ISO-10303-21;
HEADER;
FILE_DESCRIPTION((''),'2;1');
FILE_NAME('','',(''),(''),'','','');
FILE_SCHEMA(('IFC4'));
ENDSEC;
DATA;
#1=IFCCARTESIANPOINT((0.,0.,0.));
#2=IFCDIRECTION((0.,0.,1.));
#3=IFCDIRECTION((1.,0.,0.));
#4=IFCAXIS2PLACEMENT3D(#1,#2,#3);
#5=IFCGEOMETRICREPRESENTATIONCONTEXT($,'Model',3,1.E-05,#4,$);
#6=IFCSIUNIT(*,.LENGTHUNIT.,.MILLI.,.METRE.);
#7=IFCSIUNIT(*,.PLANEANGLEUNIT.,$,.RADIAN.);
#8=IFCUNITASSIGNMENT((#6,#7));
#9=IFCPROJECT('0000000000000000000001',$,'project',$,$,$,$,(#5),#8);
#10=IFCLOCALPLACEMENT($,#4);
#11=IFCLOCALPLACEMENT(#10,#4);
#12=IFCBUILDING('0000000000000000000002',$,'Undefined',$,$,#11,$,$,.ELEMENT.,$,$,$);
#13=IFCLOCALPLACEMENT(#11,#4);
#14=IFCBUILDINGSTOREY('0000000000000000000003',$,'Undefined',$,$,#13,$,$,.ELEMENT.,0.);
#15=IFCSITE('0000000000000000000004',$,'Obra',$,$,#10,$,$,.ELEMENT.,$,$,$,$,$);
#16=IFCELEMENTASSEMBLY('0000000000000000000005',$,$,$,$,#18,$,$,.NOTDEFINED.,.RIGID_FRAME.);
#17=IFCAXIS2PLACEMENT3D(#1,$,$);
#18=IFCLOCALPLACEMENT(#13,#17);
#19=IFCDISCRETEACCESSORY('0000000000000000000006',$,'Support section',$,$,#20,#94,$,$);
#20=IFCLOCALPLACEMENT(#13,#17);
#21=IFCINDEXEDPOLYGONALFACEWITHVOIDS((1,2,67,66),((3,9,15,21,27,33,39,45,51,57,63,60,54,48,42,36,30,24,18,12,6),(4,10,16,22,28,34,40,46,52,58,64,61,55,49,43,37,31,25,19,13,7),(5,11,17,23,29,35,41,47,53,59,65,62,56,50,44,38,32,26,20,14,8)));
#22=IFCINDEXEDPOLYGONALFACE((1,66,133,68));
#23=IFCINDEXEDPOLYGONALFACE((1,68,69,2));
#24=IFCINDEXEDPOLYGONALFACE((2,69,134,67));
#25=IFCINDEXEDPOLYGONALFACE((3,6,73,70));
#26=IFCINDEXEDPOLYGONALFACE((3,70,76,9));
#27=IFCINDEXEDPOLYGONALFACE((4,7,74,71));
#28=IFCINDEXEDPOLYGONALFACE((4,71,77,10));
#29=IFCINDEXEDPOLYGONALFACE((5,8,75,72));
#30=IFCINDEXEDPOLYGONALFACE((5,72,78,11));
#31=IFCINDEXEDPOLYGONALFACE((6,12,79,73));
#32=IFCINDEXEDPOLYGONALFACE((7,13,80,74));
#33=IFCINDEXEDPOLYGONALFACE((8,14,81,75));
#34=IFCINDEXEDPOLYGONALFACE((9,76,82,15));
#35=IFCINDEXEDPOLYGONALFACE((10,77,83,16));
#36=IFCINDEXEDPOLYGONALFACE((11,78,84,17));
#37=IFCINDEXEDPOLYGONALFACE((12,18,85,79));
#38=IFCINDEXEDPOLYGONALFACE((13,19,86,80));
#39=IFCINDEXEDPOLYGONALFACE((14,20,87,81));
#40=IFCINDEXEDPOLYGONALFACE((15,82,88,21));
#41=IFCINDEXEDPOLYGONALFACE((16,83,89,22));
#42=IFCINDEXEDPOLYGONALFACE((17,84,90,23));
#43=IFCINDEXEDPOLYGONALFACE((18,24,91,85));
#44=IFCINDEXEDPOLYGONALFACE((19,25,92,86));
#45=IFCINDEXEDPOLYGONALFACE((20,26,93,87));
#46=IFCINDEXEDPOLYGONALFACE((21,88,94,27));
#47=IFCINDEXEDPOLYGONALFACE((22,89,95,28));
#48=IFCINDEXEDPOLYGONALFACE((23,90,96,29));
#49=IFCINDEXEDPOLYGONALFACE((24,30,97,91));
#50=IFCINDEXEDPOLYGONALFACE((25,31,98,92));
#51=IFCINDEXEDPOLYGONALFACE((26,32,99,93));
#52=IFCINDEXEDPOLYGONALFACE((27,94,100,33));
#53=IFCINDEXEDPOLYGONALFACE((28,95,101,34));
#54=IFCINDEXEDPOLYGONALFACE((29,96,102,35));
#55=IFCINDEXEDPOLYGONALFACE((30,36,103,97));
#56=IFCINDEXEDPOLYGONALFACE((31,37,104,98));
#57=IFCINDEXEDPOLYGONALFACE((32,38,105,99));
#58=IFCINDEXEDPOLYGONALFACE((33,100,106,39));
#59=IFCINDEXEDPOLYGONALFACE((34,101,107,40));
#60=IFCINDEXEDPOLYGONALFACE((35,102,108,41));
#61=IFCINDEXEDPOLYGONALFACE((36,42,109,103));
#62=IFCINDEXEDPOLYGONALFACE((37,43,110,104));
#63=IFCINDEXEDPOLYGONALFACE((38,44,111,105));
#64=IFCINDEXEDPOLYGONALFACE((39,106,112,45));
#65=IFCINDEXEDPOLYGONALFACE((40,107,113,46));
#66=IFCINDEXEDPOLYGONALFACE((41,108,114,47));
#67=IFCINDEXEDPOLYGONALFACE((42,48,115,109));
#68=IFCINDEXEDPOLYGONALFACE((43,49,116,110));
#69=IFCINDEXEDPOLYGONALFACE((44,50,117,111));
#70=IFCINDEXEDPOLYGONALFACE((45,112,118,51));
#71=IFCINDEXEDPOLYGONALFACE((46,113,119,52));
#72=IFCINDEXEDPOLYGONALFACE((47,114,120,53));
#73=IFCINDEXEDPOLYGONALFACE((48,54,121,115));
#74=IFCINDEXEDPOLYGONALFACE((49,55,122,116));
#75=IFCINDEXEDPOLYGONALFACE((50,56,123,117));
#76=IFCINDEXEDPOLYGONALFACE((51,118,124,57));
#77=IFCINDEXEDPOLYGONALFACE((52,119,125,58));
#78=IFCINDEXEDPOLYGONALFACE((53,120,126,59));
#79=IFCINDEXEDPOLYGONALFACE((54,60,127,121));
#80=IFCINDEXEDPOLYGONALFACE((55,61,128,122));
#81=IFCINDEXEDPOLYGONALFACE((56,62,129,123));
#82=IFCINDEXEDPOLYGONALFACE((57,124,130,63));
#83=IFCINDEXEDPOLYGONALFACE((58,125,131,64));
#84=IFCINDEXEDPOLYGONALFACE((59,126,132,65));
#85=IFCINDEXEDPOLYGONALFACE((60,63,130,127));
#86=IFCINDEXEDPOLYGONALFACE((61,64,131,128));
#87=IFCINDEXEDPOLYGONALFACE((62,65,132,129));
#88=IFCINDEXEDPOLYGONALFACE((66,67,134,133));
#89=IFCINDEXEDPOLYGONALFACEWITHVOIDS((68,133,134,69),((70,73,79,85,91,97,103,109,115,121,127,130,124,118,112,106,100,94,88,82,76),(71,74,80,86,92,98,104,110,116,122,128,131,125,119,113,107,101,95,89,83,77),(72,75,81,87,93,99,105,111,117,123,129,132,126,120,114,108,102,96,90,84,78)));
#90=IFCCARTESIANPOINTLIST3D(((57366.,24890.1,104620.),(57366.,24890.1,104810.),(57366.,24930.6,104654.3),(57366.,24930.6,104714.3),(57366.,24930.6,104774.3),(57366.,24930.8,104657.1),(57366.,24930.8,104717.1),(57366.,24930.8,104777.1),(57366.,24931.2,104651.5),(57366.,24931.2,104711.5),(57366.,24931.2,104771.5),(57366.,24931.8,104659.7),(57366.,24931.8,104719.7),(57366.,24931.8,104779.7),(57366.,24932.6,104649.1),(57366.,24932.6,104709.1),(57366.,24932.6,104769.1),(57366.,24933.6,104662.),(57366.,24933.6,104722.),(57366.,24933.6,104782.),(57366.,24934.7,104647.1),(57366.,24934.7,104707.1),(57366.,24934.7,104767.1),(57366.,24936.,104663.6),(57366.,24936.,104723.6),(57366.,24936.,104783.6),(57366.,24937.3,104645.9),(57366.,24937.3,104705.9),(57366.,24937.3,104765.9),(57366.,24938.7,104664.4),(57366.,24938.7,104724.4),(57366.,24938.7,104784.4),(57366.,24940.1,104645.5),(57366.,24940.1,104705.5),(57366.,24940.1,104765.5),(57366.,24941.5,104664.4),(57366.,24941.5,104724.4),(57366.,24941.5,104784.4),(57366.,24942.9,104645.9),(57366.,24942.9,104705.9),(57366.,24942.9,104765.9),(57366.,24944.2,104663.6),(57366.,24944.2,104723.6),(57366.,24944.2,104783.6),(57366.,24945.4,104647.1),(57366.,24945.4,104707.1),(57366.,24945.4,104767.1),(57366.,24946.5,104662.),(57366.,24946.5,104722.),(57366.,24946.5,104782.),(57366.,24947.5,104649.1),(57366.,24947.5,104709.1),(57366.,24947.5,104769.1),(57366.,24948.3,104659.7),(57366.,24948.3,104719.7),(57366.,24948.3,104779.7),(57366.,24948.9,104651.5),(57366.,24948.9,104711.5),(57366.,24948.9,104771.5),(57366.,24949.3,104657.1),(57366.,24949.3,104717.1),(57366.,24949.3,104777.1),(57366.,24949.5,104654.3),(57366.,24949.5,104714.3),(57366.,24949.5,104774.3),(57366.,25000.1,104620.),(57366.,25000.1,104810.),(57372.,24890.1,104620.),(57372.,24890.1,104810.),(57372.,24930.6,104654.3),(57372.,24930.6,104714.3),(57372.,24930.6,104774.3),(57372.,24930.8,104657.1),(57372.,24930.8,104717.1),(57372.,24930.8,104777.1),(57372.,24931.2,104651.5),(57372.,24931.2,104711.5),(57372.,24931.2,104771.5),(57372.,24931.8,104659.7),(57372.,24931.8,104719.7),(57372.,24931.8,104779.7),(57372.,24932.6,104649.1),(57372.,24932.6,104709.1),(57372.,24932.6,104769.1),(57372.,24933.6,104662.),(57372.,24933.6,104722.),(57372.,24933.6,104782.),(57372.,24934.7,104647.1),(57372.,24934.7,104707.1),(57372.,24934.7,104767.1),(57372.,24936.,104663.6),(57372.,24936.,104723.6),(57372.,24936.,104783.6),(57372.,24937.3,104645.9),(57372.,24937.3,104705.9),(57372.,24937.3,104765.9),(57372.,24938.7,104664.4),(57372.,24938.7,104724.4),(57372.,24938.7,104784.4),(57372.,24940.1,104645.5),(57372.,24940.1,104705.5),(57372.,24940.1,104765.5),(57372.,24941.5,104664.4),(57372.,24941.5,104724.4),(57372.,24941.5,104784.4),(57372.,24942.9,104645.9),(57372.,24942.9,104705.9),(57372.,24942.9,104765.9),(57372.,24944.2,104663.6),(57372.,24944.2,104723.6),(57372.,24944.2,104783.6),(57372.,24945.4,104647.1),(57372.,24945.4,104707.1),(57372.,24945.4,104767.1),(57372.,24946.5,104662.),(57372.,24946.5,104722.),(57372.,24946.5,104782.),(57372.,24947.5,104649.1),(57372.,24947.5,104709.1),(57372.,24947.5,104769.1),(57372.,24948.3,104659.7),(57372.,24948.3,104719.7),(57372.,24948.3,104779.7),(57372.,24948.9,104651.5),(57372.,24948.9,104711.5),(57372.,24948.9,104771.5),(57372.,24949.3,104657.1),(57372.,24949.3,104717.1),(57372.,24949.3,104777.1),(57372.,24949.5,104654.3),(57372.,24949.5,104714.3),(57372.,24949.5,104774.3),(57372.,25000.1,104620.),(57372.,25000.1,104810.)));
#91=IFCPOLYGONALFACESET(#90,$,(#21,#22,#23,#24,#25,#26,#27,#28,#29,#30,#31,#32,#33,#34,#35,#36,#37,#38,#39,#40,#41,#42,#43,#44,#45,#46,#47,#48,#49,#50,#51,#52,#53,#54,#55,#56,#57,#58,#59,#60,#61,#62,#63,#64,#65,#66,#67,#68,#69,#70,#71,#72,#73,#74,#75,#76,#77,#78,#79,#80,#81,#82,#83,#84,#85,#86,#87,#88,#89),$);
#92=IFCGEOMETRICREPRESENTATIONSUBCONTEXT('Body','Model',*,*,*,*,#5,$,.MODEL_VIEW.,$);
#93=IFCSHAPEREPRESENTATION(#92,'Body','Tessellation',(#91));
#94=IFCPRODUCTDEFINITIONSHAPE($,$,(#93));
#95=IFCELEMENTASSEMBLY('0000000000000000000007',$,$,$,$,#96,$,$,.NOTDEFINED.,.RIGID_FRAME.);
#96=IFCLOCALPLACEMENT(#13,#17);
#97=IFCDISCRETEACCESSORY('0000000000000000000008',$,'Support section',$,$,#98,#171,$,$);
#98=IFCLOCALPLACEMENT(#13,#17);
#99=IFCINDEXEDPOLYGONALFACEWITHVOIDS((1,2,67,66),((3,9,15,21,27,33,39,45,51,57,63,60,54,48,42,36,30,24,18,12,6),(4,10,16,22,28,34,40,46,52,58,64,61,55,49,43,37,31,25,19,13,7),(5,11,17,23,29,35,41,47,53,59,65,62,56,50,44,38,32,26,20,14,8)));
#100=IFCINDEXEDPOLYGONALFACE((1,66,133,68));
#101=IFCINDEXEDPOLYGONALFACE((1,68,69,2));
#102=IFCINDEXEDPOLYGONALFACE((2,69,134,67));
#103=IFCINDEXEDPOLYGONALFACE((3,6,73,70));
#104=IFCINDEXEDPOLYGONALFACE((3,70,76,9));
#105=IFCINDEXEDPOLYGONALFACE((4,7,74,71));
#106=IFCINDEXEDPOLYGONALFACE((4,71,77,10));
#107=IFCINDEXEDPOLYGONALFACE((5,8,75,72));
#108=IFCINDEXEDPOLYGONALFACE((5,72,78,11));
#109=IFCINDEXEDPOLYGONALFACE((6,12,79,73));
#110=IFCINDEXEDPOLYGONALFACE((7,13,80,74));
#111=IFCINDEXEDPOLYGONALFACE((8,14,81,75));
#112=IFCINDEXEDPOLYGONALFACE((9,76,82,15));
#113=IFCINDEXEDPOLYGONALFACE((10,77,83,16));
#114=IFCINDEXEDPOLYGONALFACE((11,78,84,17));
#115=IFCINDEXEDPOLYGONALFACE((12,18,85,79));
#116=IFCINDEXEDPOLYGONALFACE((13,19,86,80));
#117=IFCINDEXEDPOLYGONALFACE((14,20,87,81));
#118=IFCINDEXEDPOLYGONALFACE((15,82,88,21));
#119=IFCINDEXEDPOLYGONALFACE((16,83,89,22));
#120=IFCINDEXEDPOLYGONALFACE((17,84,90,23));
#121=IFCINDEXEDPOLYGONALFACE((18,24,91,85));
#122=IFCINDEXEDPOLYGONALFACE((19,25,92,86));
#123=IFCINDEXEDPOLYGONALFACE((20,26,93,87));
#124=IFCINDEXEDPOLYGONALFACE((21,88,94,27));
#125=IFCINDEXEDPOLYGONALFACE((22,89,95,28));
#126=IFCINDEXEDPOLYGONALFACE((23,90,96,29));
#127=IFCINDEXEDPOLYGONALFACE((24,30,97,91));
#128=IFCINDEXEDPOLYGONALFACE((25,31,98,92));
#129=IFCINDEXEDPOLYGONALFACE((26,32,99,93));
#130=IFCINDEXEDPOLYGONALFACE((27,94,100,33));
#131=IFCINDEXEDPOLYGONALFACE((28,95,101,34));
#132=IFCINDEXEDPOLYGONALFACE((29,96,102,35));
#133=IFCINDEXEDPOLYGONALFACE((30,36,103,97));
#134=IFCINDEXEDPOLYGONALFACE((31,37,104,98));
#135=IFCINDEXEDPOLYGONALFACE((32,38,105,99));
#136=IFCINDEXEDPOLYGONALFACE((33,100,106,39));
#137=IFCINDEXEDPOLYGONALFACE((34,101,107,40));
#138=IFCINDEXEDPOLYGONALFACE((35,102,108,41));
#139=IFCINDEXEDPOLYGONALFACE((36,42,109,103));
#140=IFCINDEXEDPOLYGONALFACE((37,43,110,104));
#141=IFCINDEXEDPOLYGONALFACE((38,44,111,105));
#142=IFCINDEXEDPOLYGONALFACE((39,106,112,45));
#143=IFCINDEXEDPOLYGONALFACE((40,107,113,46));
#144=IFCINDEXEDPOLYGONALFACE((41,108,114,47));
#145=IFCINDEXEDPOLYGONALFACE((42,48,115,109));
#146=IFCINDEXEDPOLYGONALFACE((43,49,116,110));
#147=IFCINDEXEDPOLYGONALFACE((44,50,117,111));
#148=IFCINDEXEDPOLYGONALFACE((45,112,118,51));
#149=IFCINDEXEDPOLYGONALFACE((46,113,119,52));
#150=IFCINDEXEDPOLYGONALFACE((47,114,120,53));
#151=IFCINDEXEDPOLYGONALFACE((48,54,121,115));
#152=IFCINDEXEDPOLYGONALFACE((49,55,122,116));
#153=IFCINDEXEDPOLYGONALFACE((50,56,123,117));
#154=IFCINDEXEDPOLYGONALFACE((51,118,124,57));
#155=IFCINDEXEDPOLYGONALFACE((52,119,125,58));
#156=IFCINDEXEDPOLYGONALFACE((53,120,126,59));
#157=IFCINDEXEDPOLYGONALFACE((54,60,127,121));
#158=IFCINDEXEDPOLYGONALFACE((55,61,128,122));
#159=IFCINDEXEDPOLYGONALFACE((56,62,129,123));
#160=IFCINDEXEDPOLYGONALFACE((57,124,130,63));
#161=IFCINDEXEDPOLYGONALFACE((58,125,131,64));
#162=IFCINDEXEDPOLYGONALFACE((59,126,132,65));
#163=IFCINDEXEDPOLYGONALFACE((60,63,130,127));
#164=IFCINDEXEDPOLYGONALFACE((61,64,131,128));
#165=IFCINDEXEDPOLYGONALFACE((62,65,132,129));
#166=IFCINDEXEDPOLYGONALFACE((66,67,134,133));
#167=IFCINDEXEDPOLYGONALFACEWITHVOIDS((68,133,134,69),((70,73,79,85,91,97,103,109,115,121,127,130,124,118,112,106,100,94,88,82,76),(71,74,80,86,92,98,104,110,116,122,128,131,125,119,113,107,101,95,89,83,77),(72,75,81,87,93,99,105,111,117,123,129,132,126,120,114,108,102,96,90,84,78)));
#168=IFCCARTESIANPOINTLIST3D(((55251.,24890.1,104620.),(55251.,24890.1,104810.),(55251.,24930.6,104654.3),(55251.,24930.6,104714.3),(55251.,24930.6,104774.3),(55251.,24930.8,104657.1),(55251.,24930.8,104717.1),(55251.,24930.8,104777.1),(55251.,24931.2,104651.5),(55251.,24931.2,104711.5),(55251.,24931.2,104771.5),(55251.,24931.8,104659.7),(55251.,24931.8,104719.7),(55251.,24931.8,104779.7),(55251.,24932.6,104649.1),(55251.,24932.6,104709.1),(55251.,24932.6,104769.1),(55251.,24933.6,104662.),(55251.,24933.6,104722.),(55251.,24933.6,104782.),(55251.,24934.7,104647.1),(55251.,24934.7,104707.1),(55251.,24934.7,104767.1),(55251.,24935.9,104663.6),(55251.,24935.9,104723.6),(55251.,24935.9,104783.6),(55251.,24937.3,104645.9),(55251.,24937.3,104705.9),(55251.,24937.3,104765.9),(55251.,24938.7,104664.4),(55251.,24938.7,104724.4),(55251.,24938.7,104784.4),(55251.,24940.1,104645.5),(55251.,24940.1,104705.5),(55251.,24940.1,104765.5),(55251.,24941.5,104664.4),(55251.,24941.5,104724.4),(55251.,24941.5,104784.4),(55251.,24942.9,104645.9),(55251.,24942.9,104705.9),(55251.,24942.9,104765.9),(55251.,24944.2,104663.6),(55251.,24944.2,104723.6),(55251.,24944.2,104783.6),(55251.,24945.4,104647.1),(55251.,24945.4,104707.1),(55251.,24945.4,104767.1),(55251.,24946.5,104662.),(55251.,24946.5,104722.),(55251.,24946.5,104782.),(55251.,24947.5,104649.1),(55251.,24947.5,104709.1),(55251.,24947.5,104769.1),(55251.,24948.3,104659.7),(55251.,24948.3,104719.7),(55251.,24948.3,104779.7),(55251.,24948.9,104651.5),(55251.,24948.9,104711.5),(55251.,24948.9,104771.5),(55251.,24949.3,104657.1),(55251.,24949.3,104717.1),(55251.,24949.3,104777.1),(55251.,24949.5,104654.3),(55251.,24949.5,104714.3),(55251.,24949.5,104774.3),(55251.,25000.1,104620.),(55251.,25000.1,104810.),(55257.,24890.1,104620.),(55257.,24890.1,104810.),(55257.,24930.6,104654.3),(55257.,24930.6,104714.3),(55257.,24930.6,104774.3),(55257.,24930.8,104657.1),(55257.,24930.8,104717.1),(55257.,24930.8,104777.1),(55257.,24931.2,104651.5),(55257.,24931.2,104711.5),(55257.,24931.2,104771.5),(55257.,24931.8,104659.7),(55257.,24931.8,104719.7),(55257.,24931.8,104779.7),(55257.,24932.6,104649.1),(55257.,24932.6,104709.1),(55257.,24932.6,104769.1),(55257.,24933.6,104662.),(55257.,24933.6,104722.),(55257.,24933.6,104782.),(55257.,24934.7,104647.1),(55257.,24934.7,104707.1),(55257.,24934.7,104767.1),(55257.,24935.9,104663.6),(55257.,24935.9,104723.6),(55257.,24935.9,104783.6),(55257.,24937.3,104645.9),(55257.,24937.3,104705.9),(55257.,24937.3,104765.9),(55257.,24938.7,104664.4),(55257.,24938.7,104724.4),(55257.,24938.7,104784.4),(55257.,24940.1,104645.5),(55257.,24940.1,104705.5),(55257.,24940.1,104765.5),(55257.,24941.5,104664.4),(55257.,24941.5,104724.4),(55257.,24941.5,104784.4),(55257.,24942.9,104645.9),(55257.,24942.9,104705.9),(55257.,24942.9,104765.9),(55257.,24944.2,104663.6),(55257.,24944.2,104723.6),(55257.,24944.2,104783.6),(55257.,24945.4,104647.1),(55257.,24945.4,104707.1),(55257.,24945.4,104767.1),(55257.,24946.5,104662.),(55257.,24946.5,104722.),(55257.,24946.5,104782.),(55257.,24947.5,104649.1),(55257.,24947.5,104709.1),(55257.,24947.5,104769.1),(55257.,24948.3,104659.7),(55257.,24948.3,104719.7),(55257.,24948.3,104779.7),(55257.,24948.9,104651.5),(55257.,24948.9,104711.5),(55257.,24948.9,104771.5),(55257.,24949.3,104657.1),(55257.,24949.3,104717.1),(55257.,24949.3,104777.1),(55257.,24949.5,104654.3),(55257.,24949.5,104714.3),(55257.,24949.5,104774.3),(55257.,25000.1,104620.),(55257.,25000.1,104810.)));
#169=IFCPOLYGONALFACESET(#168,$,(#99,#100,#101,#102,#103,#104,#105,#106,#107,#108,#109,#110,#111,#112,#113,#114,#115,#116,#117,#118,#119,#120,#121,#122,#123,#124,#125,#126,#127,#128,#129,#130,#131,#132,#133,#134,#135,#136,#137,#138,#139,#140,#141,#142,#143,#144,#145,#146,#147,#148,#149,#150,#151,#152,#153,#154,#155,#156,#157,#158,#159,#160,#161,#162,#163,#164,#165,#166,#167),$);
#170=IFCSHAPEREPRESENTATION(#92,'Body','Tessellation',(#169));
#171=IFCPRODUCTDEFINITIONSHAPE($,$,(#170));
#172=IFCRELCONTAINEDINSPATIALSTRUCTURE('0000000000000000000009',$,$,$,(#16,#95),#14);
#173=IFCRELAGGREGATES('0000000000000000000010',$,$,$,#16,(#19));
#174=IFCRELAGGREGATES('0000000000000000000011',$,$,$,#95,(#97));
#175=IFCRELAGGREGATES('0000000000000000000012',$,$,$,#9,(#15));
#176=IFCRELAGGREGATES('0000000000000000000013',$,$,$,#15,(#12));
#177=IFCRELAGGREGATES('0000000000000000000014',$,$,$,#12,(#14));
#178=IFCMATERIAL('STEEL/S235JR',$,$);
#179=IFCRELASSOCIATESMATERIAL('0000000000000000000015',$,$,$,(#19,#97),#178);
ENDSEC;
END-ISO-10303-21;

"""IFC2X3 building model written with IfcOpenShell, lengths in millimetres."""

from ifc_helpers import new_model, si_unit, frame, origin_with_axes, origin_2d_with_axis, place, context, subcontext, project, spatial, rectangle, circle, extrude, source, transform, mapped, material, element, aggregate, save


model = new_model("IFC2X3")

# Units and contexts
model_context = context("Model", 3, precision=1e-05, world=origin_with_axes())
body_context = subcontext(model_context, "Body", "Model", "MODEL_VIEW")
ifc_project = project(units=[si_unit("LENGTHUNIT", "METRE", prefix="MILLI"), si_unit("PLANEANGLEUNIT", "RADIAN")], contexts=[model_context])

# Site, building, storey
site_placement = place(None, origin_with_axes())
site = spatial("IfcSite", under=ifc_project, at=site_placement, Name="Obra", CompositionType="ELEMENT")
building_placement = place(site_placement, origin_with_axes())
building = spatial("IfcBuilding", under=site, at=building_placement, Name="Undefined", CompositionType="ELEMENT")
storey_placement = place(building_placement, origin_with_axes())
storey = spatial("IfcBuildingStorey", under=building, at=storey_placement, Name="Undefined", CompositionType="ELEMENT", Elevation=0.0)

# Shared definitions
ifc_material = material(Name="STEEL/S235JR")

# Element assemblies, discrete accessories, openings
shared_shape_1 = source(origin_with_axes(), body_context, "Body", "SweptSolid", [
    extrude(circle(Radius=9.5, at=origin_2d_with_axis()), frame((0.0, -9.2, 0.0), z_axis=(0.0, 1.0, 0.0), x_axis=(1.0, 0.0, 0.0)), (0.0, 0.0, 1.0), 6.2),
])
assembly_1_placement = place(storey_placement, origin_with_axes())
assembly_1 = element("IfcElementAssembly", 1, at=assembly_1_placement, inside=storey, AssemblyPlace="NOTDEFINED", PredefinedType="RIGID_FRAME")
discrete_accessory_1_placement = place(assembly_1_placement, frame((57369.0, 24945.1, 104620.0), z_axis=(0.0, 0.0, 1.0), x_axis=(-0.000002, 1.0, 0.0)))
discrete_accessory_1 = element("IfcDiscreteAccessory", 2, at=discrete_accessory_1_placement, material=ifc_material, Name="Support section", context=body_context, shape_type="SweptSolid", body=[
    extrude(rectangle(XDim=6.0, YDim=110.0, at=origin_2d_with_axis()), frame((0.0, 0.0, 190.0), z_axis=(0.0, 0.0, -1.0), x_axis=(0.0, 1.0, 0.0)), (0.0, 0.0, 1.0), 190.0),
])
opening_1_placement = place(assembly_1_placement, frame((57375.1, 24990.1, 104835.0), z_axis=(0.000002, -1.0, 0.0), x_axis=(0.0, 0.0, -1.0)))
element("IfcOpeningElement", 3, at=opening_1_placement, cuts=discrete_accessory_1, ObjectType="Opening", context=body_context, shape_type="MappedRepresentation", body=[
    mapped(shared_shape_1, transform((60.0, 0.0, 50.0))),
    mapped(shared_shape_1, transform((120.0, 0.0, 50.0))),
    mapped(shared_shape_1, transform((180.0, 0.0, 50.0))),
])
aggregate(assembly_1, [discrete_accessory_1])
assembly_2_placement = place(storey_placement, origin_with_axes())
assembly_2 = element("IfcElementAssembly", 4, at=assembly_2_placement, inside=storey, AssemblyPlace="NOTDEFINED", PredefinedType="RIGID_FRAME")
discrete_accessory_2_placement = place(assembly_2_placement, frame((55254.0, 24945.1, 104620.0), z_axis=(0.0, 0.0, 1.0), x_axis=(-0.000002, 1.0, 0.0)))
discrete_accessory_2 = element("IfcDiscreteAccessory", 5, at=discrete_accessory_2_placement, material=ifc_material, Name="Support section", context=body_context, shape_type="SweptSolid", body=[
    extrude(rectangle(XDim=6.0, YDim=110.0, at=origin_2d_with_axis()), frame((0.0, 0.0, 190.0), z_axis=(0.0, 0.0, -1.0), x_axis=(0.0, 1.0, 0.0)), (0.0, 0.0, 1.0), 190.0),
])
opening_2_placement = place(assembly_2_placement, frame((55260.1, 24990.1, 104835.0), z_axis=(0.000002, -1.0, 0.0), x_axis=(0.0, 0.0, -1.0)))
element("IfcOpeningElement", 6, at=opening_2_placement, cuts=discrete_accessory_2, ObjectType="Opening", context=body_context, shape_type="MappedRepresentation", body=[
    mapped(shared_shape_1, transform((60.0, 0.0, 50.0))),
    mapped(shared_shape_1, transform((120.0, 0.0, 50.0))),
    mapped(shared_shape_1, transform((180.0, 0.0, 50.0))),
])
aggregate(assembly_2, [discrete_accessory_2])

save(model, "model.ifc")
